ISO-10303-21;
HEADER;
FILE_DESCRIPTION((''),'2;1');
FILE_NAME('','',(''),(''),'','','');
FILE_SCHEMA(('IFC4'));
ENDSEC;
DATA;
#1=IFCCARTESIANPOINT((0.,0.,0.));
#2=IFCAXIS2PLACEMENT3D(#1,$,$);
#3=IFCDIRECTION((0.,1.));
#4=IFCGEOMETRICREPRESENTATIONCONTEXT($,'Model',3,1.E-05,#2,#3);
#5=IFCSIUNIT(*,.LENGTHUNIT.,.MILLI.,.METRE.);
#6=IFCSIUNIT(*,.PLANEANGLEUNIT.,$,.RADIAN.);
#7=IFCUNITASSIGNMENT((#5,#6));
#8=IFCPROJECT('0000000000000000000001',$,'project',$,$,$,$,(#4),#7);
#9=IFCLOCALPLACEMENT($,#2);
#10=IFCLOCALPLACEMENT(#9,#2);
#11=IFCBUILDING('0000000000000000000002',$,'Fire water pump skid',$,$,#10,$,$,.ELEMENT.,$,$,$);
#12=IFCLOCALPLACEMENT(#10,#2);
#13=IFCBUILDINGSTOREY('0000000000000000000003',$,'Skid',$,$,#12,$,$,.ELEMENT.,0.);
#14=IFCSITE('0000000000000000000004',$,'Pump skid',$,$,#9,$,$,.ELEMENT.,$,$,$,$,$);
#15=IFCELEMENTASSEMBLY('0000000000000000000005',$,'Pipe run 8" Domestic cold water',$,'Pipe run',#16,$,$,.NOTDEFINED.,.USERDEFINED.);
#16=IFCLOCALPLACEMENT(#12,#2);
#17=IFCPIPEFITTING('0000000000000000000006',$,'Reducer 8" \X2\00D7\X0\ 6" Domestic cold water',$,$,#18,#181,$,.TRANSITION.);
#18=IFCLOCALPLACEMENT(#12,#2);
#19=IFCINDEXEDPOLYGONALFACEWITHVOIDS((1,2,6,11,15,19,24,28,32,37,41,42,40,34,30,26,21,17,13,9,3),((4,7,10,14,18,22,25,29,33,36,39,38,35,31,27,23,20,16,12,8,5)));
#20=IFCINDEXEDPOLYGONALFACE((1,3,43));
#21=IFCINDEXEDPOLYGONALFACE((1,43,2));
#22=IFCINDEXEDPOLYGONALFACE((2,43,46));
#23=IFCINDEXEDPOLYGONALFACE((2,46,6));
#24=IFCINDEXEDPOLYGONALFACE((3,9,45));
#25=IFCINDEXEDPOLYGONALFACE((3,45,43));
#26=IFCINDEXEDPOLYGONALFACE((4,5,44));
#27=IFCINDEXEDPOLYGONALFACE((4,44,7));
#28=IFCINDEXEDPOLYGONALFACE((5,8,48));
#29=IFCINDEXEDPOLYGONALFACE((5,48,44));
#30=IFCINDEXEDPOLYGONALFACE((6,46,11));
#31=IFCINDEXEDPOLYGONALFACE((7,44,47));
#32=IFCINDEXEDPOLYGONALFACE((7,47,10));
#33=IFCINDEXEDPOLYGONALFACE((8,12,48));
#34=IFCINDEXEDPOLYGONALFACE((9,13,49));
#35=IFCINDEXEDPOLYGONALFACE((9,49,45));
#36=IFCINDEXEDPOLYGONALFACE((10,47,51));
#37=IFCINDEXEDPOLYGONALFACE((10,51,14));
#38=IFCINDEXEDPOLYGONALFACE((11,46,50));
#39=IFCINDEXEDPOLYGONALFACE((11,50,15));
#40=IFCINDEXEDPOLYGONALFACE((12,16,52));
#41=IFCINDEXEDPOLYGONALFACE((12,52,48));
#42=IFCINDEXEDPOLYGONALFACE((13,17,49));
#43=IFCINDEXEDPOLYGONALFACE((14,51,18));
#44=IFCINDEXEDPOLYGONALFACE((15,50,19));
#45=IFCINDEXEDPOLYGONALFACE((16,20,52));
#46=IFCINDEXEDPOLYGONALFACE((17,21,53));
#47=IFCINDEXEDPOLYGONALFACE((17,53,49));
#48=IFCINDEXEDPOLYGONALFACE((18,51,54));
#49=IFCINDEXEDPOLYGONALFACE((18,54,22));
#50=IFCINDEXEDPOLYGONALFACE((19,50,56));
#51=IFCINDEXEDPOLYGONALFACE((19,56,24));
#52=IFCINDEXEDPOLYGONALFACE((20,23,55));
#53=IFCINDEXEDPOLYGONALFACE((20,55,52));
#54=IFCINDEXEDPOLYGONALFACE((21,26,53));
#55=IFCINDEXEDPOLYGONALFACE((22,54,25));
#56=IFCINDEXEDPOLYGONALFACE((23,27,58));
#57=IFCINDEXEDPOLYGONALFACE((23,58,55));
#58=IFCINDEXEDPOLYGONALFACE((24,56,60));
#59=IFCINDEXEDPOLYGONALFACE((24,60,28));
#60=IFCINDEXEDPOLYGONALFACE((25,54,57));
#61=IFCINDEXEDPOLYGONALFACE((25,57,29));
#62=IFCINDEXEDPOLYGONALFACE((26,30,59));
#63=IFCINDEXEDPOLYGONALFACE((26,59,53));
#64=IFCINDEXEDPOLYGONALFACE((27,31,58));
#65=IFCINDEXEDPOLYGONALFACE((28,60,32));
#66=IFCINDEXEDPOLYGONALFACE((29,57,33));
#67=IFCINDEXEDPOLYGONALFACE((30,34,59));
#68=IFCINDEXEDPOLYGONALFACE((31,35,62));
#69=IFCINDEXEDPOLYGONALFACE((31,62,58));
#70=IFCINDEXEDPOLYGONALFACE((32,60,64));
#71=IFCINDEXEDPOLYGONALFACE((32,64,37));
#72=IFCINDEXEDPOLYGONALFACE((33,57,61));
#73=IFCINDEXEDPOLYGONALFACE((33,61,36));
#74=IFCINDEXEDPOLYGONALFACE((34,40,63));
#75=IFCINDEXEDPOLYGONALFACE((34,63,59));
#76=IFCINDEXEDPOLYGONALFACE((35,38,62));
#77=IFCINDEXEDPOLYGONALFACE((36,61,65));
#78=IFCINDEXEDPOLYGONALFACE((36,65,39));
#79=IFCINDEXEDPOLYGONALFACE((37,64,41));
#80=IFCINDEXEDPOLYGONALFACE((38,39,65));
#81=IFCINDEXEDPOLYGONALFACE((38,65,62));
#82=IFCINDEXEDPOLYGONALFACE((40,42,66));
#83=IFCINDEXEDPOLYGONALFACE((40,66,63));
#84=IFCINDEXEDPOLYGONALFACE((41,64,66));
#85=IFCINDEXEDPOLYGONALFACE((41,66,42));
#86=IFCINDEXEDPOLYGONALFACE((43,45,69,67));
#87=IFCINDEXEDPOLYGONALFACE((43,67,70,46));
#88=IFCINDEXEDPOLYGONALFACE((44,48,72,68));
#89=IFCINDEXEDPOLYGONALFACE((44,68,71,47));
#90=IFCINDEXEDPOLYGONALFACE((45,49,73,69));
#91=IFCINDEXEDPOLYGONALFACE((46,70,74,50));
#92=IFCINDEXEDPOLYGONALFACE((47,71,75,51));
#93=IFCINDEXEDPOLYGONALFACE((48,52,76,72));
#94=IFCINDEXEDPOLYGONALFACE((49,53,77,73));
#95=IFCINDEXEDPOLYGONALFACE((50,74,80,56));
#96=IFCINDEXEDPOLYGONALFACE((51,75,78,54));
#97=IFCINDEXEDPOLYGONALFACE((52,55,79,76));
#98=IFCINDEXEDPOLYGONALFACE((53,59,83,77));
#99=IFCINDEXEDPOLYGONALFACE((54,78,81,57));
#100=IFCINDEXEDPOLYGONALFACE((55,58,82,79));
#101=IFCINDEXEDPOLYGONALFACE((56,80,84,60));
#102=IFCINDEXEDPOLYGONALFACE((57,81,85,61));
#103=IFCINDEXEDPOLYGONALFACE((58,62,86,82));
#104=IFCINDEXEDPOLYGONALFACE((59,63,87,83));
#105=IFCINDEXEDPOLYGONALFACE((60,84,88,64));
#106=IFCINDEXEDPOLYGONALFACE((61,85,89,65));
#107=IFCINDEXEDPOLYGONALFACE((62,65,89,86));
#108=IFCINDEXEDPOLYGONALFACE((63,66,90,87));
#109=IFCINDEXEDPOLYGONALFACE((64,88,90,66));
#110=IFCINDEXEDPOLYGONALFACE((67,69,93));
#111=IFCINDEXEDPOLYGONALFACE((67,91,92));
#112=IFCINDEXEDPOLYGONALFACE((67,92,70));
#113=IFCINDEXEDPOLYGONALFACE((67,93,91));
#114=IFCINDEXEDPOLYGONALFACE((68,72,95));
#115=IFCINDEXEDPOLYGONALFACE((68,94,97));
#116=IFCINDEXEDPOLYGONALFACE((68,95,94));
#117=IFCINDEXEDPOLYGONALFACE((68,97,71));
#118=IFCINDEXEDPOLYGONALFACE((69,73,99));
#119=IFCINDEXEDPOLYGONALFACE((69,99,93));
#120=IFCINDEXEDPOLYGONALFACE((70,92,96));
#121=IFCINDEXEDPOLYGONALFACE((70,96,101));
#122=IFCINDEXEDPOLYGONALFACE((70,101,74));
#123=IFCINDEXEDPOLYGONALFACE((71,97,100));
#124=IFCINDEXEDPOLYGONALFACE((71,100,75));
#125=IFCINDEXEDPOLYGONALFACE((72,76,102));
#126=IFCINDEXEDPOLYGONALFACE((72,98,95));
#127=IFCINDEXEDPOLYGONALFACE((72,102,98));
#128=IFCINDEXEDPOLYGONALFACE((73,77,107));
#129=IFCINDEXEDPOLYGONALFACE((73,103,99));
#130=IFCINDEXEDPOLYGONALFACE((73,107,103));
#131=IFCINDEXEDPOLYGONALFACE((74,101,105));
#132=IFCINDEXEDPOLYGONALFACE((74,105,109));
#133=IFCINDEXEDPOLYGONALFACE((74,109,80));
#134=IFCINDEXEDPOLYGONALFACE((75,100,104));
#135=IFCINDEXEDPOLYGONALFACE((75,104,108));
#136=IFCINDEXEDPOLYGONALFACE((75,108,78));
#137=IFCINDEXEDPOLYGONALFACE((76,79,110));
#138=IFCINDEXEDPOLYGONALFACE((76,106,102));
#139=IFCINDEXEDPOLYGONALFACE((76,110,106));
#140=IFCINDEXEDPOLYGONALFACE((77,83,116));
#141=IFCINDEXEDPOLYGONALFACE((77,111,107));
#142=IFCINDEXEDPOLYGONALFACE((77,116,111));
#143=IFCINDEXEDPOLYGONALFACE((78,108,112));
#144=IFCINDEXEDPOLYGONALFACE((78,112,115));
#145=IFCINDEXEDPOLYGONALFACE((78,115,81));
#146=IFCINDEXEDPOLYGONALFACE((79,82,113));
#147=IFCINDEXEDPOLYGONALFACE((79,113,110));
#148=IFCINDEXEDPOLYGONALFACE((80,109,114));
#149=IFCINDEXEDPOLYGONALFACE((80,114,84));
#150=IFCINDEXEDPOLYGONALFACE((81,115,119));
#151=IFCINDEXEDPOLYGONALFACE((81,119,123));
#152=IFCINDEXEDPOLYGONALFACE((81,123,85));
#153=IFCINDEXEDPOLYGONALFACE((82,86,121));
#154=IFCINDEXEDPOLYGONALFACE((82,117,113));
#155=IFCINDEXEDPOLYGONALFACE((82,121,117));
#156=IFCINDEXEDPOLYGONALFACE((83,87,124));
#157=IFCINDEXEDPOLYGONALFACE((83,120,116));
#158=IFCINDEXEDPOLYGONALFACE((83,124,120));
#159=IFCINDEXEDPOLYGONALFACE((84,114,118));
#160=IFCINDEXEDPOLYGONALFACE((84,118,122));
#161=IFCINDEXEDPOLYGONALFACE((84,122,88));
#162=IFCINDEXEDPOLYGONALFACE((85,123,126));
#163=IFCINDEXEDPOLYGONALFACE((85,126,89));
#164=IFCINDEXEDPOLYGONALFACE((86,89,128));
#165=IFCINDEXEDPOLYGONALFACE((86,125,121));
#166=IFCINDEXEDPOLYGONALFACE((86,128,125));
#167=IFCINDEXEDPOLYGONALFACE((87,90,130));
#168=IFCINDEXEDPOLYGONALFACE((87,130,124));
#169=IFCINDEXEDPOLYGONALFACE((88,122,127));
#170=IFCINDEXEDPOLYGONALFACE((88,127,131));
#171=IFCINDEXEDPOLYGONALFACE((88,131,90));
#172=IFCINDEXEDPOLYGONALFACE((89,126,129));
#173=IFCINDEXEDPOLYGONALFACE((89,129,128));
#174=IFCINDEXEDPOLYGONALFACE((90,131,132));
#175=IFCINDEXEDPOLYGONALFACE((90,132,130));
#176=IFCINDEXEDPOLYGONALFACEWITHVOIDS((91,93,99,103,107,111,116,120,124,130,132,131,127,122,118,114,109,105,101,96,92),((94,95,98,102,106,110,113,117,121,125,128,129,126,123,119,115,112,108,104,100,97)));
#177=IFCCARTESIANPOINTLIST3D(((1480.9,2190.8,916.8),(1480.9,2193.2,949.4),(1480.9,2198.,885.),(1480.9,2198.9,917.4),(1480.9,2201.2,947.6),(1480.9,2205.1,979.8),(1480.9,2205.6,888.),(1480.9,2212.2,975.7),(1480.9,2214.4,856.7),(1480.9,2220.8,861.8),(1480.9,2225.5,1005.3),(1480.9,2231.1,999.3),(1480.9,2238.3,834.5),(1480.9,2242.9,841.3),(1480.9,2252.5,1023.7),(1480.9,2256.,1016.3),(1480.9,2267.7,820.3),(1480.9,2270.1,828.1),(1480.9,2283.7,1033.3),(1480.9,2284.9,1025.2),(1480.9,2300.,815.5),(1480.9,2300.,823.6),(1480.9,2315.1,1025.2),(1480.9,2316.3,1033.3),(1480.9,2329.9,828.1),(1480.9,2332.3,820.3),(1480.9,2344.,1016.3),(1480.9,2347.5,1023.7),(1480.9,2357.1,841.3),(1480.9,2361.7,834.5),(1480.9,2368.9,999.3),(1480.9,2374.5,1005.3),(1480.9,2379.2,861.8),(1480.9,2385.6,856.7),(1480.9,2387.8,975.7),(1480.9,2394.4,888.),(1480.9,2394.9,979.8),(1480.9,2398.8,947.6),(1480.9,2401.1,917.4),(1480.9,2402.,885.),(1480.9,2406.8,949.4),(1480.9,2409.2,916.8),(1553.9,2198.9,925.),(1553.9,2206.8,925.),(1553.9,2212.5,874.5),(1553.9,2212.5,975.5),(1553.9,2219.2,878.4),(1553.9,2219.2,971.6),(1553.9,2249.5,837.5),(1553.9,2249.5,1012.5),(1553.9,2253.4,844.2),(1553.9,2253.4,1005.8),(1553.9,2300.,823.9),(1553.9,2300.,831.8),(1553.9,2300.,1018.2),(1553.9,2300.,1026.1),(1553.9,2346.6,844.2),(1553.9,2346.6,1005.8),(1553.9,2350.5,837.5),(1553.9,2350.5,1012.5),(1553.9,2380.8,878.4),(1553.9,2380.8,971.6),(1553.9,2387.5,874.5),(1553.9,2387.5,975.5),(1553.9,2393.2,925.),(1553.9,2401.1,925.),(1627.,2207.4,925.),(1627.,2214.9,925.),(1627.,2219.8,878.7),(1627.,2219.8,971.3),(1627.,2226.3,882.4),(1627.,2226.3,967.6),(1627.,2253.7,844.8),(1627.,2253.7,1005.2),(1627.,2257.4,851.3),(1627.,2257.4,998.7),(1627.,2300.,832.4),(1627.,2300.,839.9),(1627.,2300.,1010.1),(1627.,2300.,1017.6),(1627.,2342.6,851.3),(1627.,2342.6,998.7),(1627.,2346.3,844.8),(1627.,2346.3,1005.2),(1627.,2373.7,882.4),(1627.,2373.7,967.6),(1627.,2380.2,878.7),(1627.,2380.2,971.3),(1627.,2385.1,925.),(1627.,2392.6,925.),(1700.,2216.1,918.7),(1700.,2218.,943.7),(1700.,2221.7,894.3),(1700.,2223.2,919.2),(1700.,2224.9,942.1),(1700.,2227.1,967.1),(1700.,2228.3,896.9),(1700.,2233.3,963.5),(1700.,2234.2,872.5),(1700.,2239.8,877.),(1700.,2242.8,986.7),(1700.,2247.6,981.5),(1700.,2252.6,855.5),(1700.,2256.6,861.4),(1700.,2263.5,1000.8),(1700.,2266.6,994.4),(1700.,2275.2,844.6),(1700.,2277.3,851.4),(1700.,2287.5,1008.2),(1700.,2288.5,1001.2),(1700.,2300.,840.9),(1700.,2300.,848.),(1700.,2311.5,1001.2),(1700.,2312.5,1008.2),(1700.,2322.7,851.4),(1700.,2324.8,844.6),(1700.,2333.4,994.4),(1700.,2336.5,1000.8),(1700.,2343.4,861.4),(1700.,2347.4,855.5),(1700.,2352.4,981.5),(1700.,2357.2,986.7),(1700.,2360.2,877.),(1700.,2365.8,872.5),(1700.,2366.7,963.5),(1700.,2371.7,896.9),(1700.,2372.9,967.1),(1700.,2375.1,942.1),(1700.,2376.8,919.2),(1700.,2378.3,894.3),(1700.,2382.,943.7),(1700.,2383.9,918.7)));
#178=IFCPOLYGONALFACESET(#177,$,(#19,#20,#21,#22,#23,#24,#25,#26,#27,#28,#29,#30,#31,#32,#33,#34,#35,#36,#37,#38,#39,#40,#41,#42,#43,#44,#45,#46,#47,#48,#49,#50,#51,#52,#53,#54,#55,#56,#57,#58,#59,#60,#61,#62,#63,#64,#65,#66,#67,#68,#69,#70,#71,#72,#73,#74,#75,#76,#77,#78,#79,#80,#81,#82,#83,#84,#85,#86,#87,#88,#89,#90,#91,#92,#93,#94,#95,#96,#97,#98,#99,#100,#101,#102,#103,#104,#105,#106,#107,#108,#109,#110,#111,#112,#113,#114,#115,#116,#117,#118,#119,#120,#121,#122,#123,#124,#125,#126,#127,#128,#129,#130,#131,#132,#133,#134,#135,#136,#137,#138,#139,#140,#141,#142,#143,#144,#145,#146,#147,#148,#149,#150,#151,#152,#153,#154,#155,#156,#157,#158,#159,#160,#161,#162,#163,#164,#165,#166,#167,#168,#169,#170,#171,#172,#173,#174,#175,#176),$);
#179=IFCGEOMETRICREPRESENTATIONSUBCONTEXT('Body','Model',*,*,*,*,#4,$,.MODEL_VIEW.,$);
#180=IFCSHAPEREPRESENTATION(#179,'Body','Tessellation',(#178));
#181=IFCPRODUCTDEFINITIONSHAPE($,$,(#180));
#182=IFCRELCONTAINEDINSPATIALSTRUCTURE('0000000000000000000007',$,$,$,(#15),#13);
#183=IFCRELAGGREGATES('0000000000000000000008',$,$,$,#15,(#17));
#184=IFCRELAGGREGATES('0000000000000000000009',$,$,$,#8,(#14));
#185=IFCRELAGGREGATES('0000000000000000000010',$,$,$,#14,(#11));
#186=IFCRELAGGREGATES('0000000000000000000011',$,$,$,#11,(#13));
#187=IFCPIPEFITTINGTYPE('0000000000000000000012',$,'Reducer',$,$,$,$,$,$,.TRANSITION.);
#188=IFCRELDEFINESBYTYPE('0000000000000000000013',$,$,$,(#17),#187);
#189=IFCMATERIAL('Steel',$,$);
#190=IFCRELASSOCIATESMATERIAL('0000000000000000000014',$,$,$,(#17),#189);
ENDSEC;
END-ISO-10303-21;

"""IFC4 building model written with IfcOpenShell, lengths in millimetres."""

from ifc_helpers import new_model, entity, si_unit, direction, origin, origin_with_axes, place, context, subcontext, project, spatial, material, type_object, element, aggregate, save


model = new_model("IFC4")

# Units and contexts
model_context = context("Model", 3, precision=1e-05, world=origin(), true_north=direction((0.0, 1.0)))
body_context = subcontext(model_context, "Body", "Model", "MODEL_VIEW")
ifc_project = project(units=[si_unit("LENGTHUNIT", "METRE", prefix="MILLI"), si_unit("PLANEANGLEUNIT", "RADIAN")], contexts=[model_context])

# Site, building, storey
site_placement = place(None, origin())
site = spatial("IfcSite", under=ifc_project, at=site_placement, Name="Pump skid", CompositionType="ELEMENT")
building_placement = place(site_placement, origin())
building = spatial("IfcBuilding", under=site, at=building_placement, Name="Fire water pump skid", CompositionType="ELEMENT")
storey_placement = place(building_placement, origin())
storey = spatial("IfcBuildingStorey", under=building, at=storey_placement, Name="Skid", CompositionType="ELEMENT", Elevation=0.0)

# Element assembly
assembly_1_placement = place(storey_placement, origin_with_axes())
assembly_1 = element("IfcElementAssembly", 1, at=assembly_1_placement, inside=storey, Name="Pipe run 8\" Domestic cold water", ObjectType="Pipe run", AssemblyPlace="NOTDEFINED", PredefinedType="USERDEFINED")
ifc_material = material(Name="Steel")

# Pipe fitting
pipe_fitting_type_1 = type_object("IfcPipeFittingType", Name="Reducer", PredefinedType="TRANSITION")
pipe_fitting_1_placement = place(storey_placement, origin_with_axes())
cartesian_point_1 = entity("IfcCartesianPoint", [0.0, 101.4])
pipe_fitting_1 = element("IfcPipeFitting", 2, at=pipe_fitting_1_placement, type_object=pipe_fitting_type_1, material=ifc_material, Name="Reducer 8\" × 6\" Domestic cold water", PredefinedType="TRANSITION", context=body_context, shape_type="SweptSolid", body=[
    entity("IfcRevolvedAreaSolid", entity("IfcArbitraryClosedProfileDef", "AREA", None, entity("IfcPolyline", [cartesian_point_1, entity("IfcCartesianPoint", [0.0, 109.5]), entity("IfcCartesianPoint", [219.1, 84.1]), entity("IfcCartesianPoint", [219.1, 77.0]), cartesian_point_1])), entity("IfcAxis2Placement3D", entity("IfcCartesianPoint", [1480.9, 2300.0, 925.0]), entity("IfcDirection", [0.0, 1.0, 0.0]), entity("IfcDirection", [1.0, 0.0, 0.0])), entity("IfcAxis1Placement", entity("IfcCartesianPoint", [0.0, 0.0, 0.0]), entity("IfcDirection", [1.0, 0.0, 0.0])), 6.283185),
])
aggregate(assembly_1, [pipe_fitting_1])

save(model, "model.ifc")
